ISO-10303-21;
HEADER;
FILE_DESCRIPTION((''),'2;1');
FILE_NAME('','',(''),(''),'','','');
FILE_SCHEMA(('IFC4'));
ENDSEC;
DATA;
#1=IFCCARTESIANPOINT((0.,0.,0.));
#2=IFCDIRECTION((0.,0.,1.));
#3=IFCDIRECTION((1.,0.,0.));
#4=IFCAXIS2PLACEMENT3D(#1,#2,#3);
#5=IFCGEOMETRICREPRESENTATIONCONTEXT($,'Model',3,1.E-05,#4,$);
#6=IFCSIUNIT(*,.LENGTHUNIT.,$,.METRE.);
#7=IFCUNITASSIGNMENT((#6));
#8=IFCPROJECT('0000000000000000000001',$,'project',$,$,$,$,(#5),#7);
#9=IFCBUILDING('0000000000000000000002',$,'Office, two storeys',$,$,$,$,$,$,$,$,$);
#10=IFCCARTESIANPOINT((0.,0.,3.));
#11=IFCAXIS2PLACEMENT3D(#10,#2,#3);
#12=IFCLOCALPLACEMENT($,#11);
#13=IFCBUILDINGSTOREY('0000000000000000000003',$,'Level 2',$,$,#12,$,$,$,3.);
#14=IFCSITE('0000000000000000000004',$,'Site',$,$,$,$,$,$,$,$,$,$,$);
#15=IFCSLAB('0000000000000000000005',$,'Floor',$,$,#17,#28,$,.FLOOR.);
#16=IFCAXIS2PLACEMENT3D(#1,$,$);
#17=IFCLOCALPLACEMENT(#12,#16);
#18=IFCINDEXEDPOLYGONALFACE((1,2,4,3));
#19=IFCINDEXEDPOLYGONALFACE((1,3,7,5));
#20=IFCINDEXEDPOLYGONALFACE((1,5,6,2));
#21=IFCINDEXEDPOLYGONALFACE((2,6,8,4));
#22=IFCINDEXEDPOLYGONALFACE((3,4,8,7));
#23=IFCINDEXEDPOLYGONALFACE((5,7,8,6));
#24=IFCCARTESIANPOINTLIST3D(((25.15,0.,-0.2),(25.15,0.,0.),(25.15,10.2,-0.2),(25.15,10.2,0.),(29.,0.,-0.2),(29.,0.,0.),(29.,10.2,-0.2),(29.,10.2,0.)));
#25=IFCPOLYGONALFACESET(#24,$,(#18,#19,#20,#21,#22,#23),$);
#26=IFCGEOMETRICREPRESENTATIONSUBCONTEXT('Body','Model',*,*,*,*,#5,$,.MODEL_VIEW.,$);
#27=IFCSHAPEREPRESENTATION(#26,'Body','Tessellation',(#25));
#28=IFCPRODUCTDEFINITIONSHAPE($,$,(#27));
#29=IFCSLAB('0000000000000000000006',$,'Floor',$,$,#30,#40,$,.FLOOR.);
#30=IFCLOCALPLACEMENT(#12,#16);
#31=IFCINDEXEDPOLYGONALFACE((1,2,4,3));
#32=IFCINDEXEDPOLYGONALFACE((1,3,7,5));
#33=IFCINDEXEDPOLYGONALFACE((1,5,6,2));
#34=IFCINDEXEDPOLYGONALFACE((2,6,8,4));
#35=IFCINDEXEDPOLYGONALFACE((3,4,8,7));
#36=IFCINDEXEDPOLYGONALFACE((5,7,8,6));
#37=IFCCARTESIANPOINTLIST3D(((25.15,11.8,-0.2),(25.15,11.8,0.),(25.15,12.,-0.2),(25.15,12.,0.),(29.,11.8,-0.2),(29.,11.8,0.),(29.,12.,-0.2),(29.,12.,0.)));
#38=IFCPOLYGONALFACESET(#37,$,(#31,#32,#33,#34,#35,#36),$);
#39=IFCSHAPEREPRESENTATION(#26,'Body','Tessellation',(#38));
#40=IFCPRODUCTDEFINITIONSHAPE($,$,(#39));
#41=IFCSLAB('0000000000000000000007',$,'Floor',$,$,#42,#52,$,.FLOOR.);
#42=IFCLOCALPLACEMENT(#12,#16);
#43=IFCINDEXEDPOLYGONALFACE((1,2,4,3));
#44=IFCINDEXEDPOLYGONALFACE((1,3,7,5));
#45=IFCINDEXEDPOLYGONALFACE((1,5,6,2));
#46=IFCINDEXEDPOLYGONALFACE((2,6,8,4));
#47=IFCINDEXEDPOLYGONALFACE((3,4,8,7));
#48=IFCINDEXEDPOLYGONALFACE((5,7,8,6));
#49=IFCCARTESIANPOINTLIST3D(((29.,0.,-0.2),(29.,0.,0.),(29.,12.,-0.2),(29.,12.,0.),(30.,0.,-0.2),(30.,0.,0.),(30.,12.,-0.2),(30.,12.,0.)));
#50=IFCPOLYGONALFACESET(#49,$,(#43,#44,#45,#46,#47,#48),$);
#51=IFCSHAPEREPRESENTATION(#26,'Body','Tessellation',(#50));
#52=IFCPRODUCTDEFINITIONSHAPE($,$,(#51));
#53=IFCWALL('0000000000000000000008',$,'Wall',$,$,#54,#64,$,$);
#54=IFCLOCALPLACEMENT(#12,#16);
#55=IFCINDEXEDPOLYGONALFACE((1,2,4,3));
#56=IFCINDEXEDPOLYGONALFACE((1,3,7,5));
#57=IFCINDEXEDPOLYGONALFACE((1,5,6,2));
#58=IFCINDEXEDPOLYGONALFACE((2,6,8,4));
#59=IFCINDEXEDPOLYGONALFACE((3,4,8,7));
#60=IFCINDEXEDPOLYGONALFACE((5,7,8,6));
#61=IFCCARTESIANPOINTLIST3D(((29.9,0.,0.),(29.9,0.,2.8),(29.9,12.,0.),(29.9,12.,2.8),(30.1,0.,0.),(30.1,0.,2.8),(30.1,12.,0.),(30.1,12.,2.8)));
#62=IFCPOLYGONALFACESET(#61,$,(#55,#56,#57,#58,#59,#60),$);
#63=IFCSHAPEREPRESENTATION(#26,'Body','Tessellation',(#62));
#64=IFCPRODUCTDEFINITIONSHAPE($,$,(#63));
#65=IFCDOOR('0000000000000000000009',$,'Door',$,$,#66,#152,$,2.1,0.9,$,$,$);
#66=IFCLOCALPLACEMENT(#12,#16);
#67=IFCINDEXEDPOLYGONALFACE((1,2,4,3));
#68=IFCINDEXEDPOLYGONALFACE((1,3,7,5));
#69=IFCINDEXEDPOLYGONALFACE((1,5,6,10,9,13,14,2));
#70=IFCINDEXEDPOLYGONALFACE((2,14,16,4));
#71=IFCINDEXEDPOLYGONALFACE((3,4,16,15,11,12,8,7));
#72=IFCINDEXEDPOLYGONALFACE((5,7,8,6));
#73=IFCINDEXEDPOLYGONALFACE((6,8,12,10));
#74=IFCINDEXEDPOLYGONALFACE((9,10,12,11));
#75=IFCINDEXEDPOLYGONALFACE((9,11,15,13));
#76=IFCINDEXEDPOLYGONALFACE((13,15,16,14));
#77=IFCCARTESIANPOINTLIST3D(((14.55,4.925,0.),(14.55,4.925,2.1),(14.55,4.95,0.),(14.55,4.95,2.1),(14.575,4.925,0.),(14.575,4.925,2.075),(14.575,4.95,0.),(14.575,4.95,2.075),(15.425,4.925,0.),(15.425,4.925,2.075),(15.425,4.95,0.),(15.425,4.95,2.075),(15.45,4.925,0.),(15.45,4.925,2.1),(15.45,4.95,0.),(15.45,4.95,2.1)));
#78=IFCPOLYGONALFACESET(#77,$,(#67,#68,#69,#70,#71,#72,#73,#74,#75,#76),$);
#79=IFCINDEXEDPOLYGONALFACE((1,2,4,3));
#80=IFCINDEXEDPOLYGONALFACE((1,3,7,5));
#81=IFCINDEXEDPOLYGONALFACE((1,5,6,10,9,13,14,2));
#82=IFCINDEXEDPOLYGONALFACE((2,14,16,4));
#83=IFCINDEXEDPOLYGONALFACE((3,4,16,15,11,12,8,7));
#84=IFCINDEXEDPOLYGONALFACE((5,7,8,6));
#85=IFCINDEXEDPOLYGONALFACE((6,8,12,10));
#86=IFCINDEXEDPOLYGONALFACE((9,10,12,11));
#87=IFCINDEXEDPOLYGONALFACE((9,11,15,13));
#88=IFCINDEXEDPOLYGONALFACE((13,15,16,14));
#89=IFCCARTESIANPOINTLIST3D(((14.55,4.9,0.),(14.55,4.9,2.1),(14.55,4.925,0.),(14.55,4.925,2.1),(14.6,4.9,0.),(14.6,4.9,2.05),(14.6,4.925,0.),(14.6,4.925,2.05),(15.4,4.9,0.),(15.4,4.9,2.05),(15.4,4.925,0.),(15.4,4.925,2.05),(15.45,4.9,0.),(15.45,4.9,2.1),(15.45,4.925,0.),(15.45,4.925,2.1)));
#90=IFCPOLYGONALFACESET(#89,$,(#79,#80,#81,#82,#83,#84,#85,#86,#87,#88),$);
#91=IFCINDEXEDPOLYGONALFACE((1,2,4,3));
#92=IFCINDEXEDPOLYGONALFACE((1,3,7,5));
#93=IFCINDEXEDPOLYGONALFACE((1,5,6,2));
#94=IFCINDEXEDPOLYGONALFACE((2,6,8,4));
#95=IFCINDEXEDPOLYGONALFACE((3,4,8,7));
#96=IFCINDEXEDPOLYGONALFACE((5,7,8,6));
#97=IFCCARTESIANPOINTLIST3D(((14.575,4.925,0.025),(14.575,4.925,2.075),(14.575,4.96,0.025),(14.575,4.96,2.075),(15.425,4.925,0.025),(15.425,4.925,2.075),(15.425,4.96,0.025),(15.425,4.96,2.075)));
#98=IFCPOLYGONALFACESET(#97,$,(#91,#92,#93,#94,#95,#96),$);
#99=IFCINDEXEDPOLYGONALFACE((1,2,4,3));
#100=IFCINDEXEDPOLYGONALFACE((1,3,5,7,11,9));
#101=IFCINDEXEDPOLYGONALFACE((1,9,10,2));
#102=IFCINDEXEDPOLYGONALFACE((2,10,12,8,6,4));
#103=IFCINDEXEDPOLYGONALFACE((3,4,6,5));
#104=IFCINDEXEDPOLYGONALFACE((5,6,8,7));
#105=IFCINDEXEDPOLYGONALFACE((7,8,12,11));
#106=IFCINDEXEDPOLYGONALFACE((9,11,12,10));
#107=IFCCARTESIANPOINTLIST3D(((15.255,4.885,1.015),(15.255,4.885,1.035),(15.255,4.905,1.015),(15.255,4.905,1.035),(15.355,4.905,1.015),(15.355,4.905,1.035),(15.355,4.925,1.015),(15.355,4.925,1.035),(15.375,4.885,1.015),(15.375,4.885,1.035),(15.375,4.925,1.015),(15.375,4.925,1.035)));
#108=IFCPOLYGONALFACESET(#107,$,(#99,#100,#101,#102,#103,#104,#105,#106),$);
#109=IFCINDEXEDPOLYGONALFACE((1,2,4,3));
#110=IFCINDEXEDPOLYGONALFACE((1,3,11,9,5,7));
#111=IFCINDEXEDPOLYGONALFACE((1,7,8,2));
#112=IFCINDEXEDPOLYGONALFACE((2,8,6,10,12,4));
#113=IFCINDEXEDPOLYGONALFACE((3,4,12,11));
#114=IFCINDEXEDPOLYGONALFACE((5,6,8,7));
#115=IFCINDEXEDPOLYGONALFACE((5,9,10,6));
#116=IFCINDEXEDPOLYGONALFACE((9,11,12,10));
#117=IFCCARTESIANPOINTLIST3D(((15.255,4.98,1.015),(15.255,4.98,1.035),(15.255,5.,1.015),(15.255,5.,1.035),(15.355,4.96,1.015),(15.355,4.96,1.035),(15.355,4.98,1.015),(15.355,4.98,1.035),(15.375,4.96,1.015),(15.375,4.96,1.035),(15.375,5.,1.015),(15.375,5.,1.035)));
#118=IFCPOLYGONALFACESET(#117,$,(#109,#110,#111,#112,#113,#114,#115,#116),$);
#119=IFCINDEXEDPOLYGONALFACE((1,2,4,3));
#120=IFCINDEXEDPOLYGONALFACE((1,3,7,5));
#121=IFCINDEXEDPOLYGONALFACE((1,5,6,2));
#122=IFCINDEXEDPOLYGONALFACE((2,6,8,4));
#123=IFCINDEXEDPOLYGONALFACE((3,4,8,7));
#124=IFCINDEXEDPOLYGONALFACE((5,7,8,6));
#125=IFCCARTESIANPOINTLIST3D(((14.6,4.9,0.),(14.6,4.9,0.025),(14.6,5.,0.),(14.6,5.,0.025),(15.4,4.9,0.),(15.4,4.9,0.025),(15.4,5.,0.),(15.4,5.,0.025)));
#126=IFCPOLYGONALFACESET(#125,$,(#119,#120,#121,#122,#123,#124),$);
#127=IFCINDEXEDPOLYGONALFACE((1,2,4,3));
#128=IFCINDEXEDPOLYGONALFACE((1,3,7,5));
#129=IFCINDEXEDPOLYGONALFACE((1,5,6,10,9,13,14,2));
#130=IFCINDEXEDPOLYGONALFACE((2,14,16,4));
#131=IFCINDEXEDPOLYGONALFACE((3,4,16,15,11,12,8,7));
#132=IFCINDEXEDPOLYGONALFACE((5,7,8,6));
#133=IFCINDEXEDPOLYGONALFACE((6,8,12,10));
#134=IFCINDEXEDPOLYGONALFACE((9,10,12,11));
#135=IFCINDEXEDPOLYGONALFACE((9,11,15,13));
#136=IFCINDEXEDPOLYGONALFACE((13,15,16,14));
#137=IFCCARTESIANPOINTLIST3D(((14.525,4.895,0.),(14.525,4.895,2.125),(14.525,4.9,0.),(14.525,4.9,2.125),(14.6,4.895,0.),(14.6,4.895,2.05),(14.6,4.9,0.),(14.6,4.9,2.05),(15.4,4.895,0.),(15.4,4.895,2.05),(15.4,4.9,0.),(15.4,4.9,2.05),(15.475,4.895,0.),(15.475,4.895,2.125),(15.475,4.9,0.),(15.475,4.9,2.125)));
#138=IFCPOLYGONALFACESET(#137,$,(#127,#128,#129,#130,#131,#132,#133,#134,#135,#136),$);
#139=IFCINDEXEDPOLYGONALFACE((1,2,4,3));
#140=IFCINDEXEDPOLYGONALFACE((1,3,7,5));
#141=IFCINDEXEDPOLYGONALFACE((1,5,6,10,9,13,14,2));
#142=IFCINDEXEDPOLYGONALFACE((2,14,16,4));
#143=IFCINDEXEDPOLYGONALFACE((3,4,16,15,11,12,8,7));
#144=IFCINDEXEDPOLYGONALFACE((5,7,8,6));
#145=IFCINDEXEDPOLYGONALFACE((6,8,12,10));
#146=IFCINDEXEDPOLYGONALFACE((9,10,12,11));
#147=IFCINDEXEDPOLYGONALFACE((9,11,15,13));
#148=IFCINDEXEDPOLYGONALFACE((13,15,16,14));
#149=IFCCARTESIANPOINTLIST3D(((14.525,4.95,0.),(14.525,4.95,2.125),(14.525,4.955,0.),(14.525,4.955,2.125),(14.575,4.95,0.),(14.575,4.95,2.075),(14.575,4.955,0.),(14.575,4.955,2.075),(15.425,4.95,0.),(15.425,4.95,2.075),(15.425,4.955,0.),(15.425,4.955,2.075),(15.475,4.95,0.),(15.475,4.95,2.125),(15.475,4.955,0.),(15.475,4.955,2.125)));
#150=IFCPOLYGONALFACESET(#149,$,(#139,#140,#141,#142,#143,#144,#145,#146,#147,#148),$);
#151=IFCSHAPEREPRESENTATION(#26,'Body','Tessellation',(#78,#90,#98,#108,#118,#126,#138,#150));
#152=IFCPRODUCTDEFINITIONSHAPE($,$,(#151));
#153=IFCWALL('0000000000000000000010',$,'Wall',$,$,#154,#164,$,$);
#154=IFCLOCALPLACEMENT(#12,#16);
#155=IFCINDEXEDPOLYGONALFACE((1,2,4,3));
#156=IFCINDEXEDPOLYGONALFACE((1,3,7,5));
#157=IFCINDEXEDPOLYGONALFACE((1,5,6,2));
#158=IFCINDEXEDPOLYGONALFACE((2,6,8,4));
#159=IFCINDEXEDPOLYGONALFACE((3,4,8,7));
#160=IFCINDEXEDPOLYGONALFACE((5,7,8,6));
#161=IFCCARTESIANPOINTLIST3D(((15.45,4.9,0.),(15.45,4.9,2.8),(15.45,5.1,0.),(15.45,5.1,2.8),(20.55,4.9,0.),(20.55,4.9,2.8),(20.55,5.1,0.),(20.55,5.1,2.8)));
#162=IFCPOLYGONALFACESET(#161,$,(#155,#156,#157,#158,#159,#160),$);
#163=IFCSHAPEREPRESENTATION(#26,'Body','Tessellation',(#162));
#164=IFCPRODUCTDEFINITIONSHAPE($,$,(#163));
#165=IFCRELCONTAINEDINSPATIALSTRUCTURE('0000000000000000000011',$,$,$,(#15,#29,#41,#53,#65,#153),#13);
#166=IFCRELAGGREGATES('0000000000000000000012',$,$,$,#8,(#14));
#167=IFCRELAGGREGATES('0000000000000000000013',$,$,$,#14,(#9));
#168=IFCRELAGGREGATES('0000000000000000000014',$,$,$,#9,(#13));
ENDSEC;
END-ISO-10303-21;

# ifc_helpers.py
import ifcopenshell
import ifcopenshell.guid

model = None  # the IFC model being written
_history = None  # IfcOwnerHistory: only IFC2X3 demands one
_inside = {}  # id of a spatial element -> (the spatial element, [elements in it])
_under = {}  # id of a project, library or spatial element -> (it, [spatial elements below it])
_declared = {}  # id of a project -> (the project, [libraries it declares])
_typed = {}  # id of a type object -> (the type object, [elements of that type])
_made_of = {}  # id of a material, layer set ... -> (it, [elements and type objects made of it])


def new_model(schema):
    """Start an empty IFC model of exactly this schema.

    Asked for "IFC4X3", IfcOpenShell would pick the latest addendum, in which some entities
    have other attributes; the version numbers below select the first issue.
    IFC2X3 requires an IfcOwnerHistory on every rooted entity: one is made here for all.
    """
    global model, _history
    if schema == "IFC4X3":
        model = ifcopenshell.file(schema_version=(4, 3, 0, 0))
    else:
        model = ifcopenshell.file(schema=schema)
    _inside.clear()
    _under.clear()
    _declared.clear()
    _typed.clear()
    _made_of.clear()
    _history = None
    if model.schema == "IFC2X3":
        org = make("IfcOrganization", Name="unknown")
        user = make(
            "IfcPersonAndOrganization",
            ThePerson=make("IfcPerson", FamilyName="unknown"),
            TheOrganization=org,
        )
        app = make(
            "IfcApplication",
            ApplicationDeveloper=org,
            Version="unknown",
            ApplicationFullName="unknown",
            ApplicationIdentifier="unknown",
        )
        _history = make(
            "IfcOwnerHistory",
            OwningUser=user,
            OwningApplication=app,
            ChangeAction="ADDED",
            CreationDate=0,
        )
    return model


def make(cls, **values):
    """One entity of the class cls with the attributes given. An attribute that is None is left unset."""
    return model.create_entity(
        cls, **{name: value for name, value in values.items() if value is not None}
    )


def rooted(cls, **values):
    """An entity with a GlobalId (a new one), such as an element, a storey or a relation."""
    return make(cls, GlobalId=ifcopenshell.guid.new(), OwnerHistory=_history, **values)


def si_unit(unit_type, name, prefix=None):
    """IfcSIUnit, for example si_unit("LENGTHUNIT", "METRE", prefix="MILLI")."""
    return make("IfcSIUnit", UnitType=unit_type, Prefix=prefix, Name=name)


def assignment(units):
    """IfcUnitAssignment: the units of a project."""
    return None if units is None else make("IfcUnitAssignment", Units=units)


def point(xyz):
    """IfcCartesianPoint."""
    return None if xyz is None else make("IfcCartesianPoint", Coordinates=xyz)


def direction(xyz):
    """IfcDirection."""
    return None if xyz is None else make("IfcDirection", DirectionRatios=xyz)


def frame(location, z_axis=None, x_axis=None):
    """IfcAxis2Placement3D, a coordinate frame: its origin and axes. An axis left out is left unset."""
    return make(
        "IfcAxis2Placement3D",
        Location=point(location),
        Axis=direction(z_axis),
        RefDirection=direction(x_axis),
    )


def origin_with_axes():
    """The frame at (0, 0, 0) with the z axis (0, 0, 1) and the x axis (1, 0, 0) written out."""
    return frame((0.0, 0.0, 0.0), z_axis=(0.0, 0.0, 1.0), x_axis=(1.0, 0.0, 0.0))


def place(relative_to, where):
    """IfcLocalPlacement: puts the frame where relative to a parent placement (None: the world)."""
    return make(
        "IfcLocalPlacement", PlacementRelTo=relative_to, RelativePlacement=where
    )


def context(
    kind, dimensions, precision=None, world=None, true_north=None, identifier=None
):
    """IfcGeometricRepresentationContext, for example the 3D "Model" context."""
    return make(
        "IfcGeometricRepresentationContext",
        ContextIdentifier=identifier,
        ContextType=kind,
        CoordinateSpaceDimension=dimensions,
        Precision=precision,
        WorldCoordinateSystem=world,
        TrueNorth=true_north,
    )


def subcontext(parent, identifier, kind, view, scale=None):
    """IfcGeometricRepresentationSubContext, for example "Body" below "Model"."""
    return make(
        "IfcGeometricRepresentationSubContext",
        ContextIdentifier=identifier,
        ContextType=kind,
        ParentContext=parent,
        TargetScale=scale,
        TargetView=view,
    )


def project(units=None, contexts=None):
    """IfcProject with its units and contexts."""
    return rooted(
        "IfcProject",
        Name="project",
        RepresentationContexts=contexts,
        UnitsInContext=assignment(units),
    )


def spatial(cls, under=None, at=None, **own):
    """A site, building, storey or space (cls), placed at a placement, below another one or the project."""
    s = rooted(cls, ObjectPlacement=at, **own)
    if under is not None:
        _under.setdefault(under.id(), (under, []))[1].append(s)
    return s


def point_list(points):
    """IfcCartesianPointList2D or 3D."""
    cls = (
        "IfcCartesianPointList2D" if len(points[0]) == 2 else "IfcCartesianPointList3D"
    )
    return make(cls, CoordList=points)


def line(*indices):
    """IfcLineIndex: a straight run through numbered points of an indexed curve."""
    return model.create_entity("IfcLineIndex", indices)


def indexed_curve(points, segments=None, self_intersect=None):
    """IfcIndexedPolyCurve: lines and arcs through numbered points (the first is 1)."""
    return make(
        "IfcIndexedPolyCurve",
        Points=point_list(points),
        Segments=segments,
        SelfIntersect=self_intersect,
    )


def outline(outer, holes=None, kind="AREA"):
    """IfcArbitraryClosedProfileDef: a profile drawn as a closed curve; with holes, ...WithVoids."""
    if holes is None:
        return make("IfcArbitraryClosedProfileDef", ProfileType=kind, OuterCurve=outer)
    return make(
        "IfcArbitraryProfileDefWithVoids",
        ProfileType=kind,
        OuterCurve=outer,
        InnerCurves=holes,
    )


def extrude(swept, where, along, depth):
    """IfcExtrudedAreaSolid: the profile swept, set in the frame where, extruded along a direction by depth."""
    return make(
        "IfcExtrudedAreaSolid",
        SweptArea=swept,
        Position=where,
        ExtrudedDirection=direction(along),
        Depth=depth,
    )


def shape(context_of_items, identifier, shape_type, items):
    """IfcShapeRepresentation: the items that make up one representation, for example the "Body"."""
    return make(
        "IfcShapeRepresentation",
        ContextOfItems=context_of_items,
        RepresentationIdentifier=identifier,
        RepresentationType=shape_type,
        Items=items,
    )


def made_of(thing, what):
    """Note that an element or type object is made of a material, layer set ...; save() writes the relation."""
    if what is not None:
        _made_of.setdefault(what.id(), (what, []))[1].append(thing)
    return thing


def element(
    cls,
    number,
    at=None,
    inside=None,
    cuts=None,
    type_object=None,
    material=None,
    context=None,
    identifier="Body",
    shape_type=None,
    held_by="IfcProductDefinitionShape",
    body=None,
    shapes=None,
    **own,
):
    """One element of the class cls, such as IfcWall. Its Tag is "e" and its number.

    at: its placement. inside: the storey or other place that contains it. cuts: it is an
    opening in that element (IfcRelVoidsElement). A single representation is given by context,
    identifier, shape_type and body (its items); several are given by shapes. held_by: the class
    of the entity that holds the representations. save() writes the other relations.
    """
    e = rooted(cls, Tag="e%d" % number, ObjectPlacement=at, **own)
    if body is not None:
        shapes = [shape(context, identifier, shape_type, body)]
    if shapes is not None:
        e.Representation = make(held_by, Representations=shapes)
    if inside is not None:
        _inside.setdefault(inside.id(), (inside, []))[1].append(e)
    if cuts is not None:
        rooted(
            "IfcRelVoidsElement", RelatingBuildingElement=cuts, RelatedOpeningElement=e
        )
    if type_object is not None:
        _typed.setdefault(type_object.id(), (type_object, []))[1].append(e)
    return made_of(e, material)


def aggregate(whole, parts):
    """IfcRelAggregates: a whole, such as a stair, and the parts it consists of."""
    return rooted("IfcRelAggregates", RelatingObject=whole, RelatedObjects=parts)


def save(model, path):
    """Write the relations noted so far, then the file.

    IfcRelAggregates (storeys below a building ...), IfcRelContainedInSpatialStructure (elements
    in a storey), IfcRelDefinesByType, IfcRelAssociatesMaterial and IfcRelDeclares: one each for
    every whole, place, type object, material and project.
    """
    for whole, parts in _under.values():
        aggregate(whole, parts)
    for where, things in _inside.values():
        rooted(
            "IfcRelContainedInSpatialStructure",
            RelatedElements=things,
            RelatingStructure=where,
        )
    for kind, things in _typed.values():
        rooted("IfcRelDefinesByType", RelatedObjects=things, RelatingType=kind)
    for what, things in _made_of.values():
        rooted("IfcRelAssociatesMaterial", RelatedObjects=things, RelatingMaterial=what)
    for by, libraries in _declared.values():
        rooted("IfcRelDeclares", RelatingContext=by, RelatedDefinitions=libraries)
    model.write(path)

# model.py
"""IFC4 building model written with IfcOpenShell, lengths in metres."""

from ifc_helpers import new_model, si_unit, frame, origin_with_axes, place, context, subcontext, project, spatial, line, indexed_curve, outline, extrude, element, save


model = new_model("IFC4")

# Units and contexts
model_context = context("Model", 3, precision=1e-05, world=origin_with_axes())
body_context = subcontext(model_context, "Body", "Model", "MODEL_VIEW")
ifc_project = project(units=[si_unit("LENGTHUNIT", "METRE")], contexts=[model_context])

# Site, building, storey
site = spatial("IfcSite", under=ifc_project, Name="Site")
building = spatial("IfcBuilding", under=site, Name="Office, two storeys")
storey_placement = place(None, frame((0.0, 0.0, 3.0), z_axis=(0.0, 0.0, 1.0), x_axis=(1.0, 0.0, 0.0)))
storey = spatial("IfcBuildingStorey", under=building, at=storey_placement, Name="Level 2", Elevation=3.0)

# Slabs
slab_1_placement = place(storey_placement, frame((25.15, 0.0, -0.2), z_axis=(0.0, 0.0, 1.0), x_axis=(1.0, 0.0, 0.0)))
element("IfcSlab", 1, at=slab_1_placement, inside=storey, Name="Floor", PredefinedType="FLOOR", context=body_context, shape_type="SweptSolid", body=[
    extrude(outline(indexed_curve([(0.0, 0.0), (3.85, 0.0), (3.85, 10.2), (0.0, 10.2)])), None, (0.0, 0.0, 1.0), 0.2),
])
slab_2_placement = place(storey_placement, frame((25.15, 11.8, -0.2), z_axis=(0.0, 0.0, 1.0), x_axis=(1.0, 0.0, 0.0)))
element("IfcSlab", 2, at=slab_2_placement, inside=storey, Name="Floor", PredefinedType="FLOOR", context=body_context, shape_type="SweptSolid", body=[
    extrude(outline(indexed_curve([(0.0, 0.0), (3.85, 0.0), (3.85, 0.2), (0.0, 0.2)])), None, (0.0, 0.0, 1.0), 0.2),
])
slab_3_placement = place(storey_placement, frame((29.0, 0.0, -0.2), z_axis=(0.0, 0.0, 1.0), x_axis=(1.0, 0.0, 0.0)))
element("IfcSlab", 3, at=slab_3_placement, inside=storey, Name="Floor", PredefinedType="FLOOR", context=body_context, shape_type="SweptSolid", body=[
    extrude(outline(indexed_curve([(0.0, 0.0), (1.0, 0.0), (1.0, 12.0), (0.0, 12.0)])), None, (0.0, 0.0, 1.0), 0.2),
])

# Wall
wall_1_placement = place(storey_placement, frame((30.0, 0.0, 0.0), z_axis=(0.0, 0.0, 1.0), x_axis=(0.0, 1.0, 0.0)))
element("IfcWall", 4, at=wall_1_placement, inside=storey, Name="Wall", context=body_context, shape_type="SweptSolid", body=[
    extrude(outline(indexed_curve([(0.0, 0.0), (0.0, 0.2), (12.0, 0.2), (12.0, 0.0), (0.0, 0.0)], self_intersect=False)), frame((0.0, -0.1, 0.0), z_axis=(0.0, 0.0, 1.0), x_axis=(1.0, 0.0, 0.0)), (0.0, 0.0, 1.0), 2.8),
])

# Door
door_1_placement = place(storey_placement, frame((14.55, 4.9, 0.0), z_axis=(0.0, 0.0, 1.0), x_axis=(1.0, 0.0, 0.0)))
element("IfcDoor", 5, at=door_1_placement, inside=storey, Name="Door", OverallHeight=2.1, OverallWidth=0.9, context=body_context, shape_type="SweptSolid", body=[
    extrude(outline(indexed_curve([(0.0, 0.0), (0.0, 2.1), (0.9, 2.1), (0.9, 0.0), (0.875, 0.0), (0.875, 2.075), (0.025, 2.075), (0.025, 0.0)], segments=[line(1, 2, 3, 4, 5, 6, 7, 8, 1)])), frame((0.0, 0.025, 0.0), z_axis=(0.0, -1.0, 0.0), x_axis=(1.0, 0.0, 0.0)), (0.0, 0.0, -1.0), 0.025),
    extrude(outline(indexed_curve([(0.0, 0.0), (0.0, 2.1), (0.9, 2.1), (0.9, 0.0), (0.85, 0.0), (0.85, 2.05), (0.05, 2.05), (0.05, 0.0)], segments=[line(1, 2, 3, 4, 5, 6, 7, 8, 1)])), frame((0.0, 0.0, 0.0), z_axis=(0.0, -1.0, 0.0), x_axis=(1.0, 0.0, 0.0)), (0.0, 0.0, -1.0), 0.025),
    extrude(outline(indexed_curve([(0.0, 0.0), (0.85, 0.0), (0.85, 0.035), (0.0, 0.035)], segments=[line(1, 2, 3, 4, 1)])), frame((0.025, 0.025, 0.025), z_axis=(0.0, 0.0, 1.0), x_axis=(1.0, 0.0, 0.0)), (0.0, 0.0, 1.0), 2.05),
    extrude(outline(indexed_curve([(0.0, 0.0), (0.0, -0.04), (-0.12, -0.04), (-0.12, -0.02), (-0.02, -0.02), (-0.02, 0.0)], segments=[line(1, 2, 3, 4, 5, 6, 1)])), frame((0.825, 0.025, 1.015), z_axis=(0.0, 0.0, 1.0), x_axis=(1.0, 0.0, 0.0)), (0.0, 0.0, 1.0), 0.02),
    extrude(outline(indexed_curve([(0.0, 0.0), (0.0, 0.04), (-0.12, 0.04), (-0.12, 0.02), (-0.02, 0.02), (-0.02, 0.0)], segments=[line(1, 2, 3, 4, 5, 6, 1)])), frame((0.825, 0.06, 1.015), z_axis=(0.0, 0.0, 1.0), x_axis=(1.0, 0.0, 0.0)), (0.0, 0.0, 1.0), 0.02),
    extrude(outline(indexed_curve([(0.0, 0.0), (0.8, 0.0), (0.8, 0.1), (0.0, 0.1)], segments=[line(1, 2, 3, 4, 1)])), frame((0.05, 0.0, 0.0), z_axis=(0.0, 0.0, 1.0), x_axis=(1.0, 0.0, 0.0)), (0.0, 0.0, 1.0), 0.025),
    extrude(outline(indexed_curve([(0.0, 0.0), (0.0, 2.125), (0.95, 2.125), (0.95, 0.0), (0.875, 0.0), (0.875, 2.05), (0.075, 2.05), (0.075, 0.0)], segments=[line(1, 2, 3, 4, 5, 6, 7, 8, 1)])), frame((-0.025, -0.005, 0.0), z_axis=(0.0, -1.0, 0.0), x_axis=(1.0, 0.0, 0.0)), (0.0, 0.0, -1.0), 0.005),
    extrude(outline(indexed_curve([(0.0, 0.0), (0.0, 2.125), (0.95, 2.125), (0.95, 0.0), (0.9, 0.0), (0.9, 2.075), (0.05, 2.075), (0.05, 0.0)], segments=[line(1, 2, 3, 4, 5, 6, 7, 8, 1)])), frame((-0.025, 0.05, 0.0), z_axis=(0.0, -1.0, 0.0), x_axis=(1.0, 0.0, 0.0)), (0.0, 0.0, -1.0), 0.005),
])

# Wall
wall_2_placement = place(storey_placement, frame((15.45, 5.0, 0.0), z_axis=(0.0, 0.0, 1.0), x_axis=(1.0, 0.0, 0.0)))
element("IfcWall", 6, at=wall_2_placement, inside=storey, Name="Wall", context=body_context, shape_type="SweptSolid", body=[
    extrude(outline(indexed_curve([(0.0, 0.0), (0.0, 0.2), (5.1, 0.2), (5.1, 0.0), (0.0, 0.0)], self_intersect=False)), frame((0.0, -0.1, 0.0), z_axis=(0.0, 0.0, 1.0), x_axis=(1.0, 0.0, 0.0)), (0.0, 0.0, 1.0), 2.8),
])

save(model, "model.ifc")
